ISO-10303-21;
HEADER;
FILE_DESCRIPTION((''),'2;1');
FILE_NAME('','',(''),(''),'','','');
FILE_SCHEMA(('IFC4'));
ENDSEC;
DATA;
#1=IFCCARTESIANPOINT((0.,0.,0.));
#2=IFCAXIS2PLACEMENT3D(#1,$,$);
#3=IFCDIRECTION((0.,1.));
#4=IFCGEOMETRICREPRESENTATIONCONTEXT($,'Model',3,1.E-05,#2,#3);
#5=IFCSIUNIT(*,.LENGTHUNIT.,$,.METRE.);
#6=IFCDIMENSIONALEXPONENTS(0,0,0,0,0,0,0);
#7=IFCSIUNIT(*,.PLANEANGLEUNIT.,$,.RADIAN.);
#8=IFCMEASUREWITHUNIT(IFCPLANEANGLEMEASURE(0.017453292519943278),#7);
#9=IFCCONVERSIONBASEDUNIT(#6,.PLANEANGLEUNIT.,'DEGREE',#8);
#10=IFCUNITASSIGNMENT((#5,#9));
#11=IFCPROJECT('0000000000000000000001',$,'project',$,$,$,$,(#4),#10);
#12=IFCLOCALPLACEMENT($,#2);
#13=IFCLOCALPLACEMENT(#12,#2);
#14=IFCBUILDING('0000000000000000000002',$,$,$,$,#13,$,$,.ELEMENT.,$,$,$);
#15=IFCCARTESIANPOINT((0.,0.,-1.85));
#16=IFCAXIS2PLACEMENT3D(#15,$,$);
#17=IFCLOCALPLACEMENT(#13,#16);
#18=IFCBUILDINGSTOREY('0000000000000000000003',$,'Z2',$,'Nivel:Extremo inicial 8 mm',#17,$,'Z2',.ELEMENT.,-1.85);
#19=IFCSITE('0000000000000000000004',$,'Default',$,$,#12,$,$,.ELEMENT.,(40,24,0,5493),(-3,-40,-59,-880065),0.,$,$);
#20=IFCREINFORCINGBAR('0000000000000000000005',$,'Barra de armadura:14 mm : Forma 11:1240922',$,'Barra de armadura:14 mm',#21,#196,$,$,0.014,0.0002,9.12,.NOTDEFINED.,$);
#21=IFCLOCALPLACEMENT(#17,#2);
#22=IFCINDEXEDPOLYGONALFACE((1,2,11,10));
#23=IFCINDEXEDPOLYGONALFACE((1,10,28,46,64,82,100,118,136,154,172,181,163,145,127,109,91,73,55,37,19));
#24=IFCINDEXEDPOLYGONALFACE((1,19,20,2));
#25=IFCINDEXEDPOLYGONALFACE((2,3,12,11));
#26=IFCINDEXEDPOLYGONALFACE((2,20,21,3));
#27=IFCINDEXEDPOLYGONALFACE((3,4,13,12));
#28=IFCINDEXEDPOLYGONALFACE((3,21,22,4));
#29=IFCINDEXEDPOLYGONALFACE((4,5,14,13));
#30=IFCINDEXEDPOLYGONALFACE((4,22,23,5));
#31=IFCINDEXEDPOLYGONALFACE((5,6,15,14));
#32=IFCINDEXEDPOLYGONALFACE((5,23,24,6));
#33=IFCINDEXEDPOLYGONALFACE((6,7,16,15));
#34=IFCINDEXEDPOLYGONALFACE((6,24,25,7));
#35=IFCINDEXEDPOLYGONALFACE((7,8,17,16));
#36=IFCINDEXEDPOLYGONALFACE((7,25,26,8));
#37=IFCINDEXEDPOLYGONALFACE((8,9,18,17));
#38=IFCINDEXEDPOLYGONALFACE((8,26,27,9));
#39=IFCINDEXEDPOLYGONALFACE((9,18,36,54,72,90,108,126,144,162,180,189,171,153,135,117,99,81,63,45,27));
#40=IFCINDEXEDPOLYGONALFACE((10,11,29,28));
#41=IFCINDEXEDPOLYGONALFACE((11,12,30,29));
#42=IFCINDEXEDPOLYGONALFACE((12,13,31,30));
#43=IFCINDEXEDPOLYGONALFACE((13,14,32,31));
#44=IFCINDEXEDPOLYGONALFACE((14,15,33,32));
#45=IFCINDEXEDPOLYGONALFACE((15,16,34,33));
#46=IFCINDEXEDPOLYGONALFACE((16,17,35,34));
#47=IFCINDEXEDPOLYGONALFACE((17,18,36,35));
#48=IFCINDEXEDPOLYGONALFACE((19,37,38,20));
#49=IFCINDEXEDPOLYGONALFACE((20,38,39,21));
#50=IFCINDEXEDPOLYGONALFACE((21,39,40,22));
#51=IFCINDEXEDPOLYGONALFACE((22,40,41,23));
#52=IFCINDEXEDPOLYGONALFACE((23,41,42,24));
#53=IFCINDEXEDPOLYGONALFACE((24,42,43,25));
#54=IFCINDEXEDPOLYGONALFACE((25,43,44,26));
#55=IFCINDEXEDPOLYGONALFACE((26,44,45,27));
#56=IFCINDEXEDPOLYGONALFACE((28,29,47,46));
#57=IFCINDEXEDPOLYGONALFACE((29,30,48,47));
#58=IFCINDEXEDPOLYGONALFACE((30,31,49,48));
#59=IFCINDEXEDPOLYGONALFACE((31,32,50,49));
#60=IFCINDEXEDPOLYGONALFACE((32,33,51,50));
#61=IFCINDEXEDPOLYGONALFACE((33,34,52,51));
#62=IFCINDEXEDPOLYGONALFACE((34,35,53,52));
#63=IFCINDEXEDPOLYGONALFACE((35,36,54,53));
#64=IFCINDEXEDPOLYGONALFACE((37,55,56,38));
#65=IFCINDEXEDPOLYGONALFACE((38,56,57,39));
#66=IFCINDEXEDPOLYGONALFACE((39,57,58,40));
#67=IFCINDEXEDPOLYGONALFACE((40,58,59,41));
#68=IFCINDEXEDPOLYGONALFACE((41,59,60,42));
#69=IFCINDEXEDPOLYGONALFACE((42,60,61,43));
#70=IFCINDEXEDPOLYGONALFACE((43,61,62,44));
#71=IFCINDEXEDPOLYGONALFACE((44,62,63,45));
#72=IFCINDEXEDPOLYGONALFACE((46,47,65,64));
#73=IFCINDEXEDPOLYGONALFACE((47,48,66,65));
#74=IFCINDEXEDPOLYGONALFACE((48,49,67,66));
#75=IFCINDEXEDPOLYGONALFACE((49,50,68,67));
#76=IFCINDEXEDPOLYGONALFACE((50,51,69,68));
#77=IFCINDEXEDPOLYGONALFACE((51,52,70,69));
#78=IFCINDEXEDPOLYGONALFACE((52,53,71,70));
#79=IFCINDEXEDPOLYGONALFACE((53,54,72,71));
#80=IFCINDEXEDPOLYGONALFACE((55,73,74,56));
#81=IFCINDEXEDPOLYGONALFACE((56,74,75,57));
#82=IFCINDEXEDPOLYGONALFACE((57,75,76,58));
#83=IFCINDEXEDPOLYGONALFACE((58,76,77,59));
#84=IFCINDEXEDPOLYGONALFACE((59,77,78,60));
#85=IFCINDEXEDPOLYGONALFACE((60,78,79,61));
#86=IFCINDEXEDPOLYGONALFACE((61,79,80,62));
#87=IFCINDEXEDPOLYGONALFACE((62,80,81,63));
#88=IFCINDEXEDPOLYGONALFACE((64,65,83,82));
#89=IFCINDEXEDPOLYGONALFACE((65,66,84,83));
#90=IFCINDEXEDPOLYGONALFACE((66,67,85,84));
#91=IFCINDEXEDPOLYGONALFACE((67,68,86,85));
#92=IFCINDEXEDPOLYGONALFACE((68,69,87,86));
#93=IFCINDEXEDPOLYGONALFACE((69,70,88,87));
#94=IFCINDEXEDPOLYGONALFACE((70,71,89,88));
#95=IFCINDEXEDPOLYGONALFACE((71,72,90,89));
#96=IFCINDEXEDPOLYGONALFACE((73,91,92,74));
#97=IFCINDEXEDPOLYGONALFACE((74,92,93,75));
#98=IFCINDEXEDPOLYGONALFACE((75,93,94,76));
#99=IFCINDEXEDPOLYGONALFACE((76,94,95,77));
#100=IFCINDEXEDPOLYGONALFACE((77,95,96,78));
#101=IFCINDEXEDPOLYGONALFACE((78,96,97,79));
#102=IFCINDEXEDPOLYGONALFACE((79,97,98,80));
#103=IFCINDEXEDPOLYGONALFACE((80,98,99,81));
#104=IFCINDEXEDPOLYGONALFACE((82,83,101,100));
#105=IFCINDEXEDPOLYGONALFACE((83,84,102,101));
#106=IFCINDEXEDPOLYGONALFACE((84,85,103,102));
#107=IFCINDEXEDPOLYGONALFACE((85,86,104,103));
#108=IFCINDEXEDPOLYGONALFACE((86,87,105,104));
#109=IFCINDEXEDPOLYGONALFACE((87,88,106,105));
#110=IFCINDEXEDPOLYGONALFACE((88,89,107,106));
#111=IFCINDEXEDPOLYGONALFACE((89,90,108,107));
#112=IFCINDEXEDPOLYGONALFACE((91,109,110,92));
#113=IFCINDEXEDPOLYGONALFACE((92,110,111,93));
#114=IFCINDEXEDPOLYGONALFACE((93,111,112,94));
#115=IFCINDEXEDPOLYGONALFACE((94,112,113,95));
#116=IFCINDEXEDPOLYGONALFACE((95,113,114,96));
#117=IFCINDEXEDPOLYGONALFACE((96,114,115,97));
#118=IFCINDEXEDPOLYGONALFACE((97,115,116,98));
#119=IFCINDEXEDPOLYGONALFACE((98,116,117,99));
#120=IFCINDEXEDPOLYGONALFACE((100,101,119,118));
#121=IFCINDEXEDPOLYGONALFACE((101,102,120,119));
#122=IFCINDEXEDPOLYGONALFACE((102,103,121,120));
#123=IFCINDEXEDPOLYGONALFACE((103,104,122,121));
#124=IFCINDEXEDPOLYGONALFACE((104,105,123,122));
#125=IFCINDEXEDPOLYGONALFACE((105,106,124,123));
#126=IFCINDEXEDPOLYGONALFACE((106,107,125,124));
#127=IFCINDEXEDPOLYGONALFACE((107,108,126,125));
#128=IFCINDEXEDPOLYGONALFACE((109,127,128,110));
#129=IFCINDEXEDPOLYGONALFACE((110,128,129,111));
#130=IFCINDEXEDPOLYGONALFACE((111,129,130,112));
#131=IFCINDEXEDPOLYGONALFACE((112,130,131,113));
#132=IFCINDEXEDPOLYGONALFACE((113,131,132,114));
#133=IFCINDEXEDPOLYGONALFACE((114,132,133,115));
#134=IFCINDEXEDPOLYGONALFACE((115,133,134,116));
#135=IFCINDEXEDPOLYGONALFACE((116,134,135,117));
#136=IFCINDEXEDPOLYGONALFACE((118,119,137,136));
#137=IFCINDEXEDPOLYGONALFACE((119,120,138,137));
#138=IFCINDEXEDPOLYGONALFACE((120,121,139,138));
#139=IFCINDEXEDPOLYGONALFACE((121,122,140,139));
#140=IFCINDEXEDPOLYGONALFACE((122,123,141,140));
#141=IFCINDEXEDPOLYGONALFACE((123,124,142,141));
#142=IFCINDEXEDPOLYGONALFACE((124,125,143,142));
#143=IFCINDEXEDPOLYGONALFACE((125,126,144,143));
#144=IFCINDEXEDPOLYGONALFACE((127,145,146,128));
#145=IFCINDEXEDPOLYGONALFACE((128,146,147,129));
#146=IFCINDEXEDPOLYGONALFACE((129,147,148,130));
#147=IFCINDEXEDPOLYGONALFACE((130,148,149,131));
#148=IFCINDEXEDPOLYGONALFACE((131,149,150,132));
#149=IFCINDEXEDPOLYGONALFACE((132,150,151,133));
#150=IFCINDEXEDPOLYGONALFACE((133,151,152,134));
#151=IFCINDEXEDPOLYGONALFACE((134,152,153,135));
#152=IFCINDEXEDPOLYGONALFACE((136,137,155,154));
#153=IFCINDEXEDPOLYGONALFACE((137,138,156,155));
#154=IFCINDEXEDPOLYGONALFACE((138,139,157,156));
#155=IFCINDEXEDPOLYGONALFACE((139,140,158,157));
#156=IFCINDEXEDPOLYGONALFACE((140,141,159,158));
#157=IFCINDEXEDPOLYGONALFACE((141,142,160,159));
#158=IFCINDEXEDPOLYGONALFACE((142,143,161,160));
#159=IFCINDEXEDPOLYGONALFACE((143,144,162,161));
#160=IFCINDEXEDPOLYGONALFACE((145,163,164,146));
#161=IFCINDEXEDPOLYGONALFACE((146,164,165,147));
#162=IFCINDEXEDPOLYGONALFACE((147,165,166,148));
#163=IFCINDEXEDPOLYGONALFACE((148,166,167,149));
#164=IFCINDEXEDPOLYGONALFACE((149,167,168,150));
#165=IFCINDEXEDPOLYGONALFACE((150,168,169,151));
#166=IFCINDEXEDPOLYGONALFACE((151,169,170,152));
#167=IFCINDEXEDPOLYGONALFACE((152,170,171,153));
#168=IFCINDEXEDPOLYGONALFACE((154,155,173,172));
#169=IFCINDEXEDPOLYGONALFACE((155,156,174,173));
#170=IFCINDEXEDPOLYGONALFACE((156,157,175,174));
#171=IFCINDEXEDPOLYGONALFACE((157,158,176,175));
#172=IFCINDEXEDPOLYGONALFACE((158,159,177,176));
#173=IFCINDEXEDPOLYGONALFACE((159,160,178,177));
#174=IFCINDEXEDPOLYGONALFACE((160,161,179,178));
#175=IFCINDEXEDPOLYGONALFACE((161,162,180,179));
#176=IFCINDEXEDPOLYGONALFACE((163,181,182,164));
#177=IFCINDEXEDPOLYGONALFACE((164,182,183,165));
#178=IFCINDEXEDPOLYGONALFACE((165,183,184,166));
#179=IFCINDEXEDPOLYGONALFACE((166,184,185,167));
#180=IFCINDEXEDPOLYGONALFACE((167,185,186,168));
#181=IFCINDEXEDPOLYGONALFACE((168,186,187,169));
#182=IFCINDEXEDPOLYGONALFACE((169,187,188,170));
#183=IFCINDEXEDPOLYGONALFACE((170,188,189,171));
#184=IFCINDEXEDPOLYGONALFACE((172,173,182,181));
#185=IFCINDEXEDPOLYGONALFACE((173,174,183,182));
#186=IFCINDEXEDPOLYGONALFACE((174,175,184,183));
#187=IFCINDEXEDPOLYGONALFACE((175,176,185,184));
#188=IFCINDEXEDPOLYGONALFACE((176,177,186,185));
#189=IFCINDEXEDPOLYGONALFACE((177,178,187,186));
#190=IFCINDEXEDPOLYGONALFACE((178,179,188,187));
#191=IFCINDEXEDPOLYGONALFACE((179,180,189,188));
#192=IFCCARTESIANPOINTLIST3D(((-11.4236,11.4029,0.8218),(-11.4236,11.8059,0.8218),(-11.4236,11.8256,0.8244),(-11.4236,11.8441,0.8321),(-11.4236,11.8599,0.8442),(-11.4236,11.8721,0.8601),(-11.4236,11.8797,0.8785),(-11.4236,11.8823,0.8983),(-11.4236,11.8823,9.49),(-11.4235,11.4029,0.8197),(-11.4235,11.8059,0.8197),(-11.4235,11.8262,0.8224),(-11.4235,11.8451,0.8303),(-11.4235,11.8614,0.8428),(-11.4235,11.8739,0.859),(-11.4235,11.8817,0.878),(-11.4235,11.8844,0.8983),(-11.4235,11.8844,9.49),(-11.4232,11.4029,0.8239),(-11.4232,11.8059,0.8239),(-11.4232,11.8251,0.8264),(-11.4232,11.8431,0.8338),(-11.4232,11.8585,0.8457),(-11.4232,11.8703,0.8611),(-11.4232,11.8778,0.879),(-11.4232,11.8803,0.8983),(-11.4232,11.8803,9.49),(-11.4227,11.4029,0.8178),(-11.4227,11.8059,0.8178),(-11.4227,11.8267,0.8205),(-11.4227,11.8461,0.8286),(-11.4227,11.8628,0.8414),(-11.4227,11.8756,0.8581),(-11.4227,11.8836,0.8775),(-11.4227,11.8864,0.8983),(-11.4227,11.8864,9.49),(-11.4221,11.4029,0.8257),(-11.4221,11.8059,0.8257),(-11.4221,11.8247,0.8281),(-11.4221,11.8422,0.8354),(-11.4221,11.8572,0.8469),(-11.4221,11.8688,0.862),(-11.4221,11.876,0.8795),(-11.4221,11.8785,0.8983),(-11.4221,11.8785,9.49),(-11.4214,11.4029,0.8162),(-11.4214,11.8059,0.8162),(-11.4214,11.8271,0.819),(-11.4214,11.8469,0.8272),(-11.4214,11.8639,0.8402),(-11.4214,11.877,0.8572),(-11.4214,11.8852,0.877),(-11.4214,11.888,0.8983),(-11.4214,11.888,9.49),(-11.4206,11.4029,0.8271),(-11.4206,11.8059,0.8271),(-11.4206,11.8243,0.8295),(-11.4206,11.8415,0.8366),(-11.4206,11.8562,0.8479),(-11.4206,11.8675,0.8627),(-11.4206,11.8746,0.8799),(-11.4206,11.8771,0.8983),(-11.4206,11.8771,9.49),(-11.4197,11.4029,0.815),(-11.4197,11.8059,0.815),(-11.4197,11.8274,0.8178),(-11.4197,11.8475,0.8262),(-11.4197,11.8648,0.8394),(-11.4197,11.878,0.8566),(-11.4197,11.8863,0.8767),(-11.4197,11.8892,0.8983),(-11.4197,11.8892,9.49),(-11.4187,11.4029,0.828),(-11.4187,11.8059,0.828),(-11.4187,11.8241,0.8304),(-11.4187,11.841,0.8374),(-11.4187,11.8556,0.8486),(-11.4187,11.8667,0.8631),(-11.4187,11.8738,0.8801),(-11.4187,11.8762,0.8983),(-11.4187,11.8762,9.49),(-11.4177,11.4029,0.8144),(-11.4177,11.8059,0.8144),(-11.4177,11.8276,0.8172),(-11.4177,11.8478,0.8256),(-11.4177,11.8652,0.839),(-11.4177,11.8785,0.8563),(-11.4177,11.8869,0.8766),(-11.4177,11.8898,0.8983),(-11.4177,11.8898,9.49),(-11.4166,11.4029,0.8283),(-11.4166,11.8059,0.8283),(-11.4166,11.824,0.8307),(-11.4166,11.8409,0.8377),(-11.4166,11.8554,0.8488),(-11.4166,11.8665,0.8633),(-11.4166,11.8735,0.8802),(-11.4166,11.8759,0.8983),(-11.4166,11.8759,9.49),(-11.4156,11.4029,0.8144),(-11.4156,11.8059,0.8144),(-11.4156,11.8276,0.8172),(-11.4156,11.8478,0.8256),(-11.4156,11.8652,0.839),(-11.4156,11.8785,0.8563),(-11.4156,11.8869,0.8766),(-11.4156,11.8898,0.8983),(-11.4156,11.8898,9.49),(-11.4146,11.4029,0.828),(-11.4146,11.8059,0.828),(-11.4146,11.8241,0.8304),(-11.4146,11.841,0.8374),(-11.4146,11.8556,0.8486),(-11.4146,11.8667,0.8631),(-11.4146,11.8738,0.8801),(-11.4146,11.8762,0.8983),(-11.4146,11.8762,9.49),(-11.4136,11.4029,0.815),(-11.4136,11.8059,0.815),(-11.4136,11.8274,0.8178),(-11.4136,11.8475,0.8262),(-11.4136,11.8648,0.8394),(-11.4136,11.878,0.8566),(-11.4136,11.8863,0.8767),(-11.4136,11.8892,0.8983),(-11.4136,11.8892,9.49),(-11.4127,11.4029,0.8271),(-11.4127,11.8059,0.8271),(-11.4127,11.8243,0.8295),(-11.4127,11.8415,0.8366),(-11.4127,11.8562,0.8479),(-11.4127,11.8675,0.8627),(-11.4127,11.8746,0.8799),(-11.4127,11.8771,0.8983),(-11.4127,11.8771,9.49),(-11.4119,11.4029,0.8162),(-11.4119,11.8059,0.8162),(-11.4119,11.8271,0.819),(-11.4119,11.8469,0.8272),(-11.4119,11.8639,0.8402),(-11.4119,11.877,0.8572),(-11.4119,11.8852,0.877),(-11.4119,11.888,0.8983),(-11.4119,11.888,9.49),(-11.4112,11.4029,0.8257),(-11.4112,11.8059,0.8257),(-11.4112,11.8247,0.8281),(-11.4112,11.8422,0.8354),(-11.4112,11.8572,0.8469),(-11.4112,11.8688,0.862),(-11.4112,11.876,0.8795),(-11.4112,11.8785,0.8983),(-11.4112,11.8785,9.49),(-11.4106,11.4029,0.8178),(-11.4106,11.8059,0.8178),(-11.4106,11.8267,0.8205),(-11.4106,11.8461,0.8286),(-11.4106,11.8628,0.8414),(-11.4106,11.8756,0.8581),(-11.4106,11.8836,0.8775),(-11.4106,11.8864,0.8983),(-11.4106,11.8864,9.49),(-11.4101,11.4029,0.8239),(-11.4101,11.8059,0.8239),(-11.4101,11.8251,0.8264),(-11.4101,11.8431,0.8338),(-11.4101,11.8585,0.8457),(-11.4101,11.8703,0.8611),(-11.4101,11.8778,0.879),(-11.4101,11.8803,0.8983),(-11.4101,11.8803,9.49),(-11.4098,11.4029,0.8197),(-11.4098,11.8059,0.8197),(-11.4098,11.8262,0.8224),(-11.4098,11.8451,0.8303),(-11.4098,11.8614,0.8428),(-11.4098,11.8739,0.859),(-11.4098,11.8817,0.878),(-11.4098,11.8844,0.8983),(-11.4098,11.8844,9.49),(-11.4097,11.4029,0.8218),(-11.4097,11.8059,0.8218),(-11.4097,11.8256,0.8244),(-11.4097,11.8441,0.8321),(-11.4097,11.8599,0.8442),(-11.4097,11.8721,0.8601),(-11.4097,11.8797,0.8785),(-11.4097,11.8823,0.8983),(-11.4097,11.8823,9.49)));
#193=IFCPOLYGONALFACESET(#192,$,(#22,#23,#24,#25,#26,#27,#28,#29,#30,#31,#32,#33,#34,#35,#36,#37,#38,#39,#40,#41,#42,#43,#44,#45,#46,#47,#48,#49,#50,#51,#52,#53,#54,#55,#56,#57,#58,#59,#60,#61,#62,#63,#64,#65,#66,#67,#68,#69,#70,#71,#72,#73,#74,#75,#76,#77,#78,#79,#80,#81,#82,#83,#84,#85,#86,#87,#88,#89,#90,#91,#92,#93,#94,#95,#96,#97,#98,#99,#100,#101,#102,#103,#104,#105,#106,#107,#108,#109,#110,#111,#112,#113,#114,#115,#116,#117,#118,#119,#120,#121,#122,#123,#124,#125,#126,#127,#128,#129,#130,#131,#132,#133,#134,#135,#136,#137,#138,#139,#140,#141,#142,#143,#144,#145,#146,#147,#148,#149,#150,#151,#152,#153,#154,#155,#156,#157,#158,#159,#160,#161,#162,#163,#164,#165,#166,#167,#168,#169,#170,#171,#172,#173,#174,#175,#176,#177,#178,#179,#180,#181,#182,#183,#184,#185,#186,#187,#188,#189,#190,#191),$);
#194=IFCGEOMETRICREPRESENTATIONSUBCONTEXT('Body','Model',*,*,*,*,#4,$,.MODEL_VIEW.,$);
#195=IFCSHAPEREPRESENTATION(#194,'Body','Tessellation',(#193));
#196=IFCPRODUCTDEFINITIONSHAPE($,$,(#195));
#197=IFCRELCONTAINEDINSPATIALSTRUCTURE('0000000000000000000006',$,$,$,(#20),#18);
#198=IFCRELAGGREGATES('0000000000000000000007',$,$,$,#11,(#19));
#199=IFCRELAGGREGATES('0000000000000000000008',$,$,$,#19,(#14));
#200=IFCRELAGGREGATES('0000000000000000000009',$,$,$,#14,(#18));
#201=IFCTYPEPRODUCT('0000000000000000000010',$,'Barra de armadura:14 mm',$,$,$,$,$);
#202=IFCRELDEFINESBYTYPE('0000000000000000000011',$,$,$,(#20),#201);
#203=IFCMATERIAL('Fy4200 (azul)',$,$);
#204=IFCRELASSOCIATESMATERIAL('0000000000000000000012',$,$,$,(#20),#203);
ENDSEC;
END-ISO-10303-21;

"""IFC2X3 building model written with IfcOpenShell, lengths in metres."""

from ifc_helpers import new_model, entity, si_unit, converted_unit, direction, frame, origin, place, context, subcontext, project, spatial, material, type_object, element, save


model = new_model("IFC2X3")

# Units and contexts
model_context = context("Model", 3, precision=1e-05, world=origin(), true_north=direction((0.0, 1.0)))
body_context = subcontext(model_context, "Body", "Model", "MODEL_VIEW")
ifc_project = project(units=[si_unit("LENGTHUNIT", "METRE"), converted_unit("PLANEANGLEUNIT", "DEGREE", entity("IfcPlaneAngleMeasure", 0.017453292519943278), si_unit("PLANEANGLEUNIT", "RADIAN"), dimensions=[0, 0, 0, 0, 0, 0, 0])], contexts=[model_context])

# Site, building, storey
site_placement = place(None, origin())
site = spatial("IfcSite", under=ifc_project, at=site_placement, Name="Default", CompositionType="ELEMENT", RefLatitude=(40, 24, 0, 5493), RefLongitude=(-3, -40, -59, -880065), RefElevation=0.0)
building_placement = place(site_placement, origin())
building = spatial("IfcBuilding", under=site, at=building_placement, CompositionType="ELEMENT")
storey_placement = place(building_placement, frame((0.0, 0.0, -1.85)))
storey = spatial("IfcBuildingStorey", under=building, at=storey_placement, Name="Z2", ObjectType="Nivel:Extremo inicial 8 mm", LongName="Z2", CompositionType="ELEMENT", Elevation=-1.85)

# Reinforcing bar
ifc_material_1 = material(Name="Fy4200 (azul)")
type_product_1 = type_object("IfcTypeProduct", Name="Barra de armadura:14 mm")
reinforcing_bar_1_placement = place(storey_placement, origin())
element("IfcReinforcingBar", 1, at=reinforcing_bar_1_placement, inside=storey, type_object=type_product_1, material=ifc_material_1, Name="Barra de armadura:14 mm : Forma 11:1240922", ObjectType="Barra de armadura:14 mm", BarLength=9.12, BarRole="NOTDEFINED", CrossSectionArea=0.0002, NominalDiameter=0.014, context=body_context, shape_type="AdvancedSweptSolid", body=[
    entity("IfcSweptDiskSolid", entity("IfcCompositeCurve", [entity("IfcCompositeCurveSegment", "CONTINUOUS", True, entity("IfcPolyline", [entity("IfcCartesianPoint", [-11.4166, 11.8829, 9.49]), entity("IfcCartesianPoint", [-11.4166, 11.8829, 0.8983])])), entity("IfcCompositeCurveSegment", "CONTINUOUS", True, entity("IfcTrimmedCurve", entity("IfcCircle", entity("IfcAxis2Placement3D", entity("IfcCartesianPoint", [-11.4166, 11.8059, 0.8983]), entity("IfcDirection", [-1.0, 0.0, 0.0]), entity("IfcDirection", [0.0, 0.0, -1.0])), 0.077), [entity("IfcParameterValue", 270.0)], [entity("IfcParameterValue", 360.0)], True, "PARAMETER")), entity("IfcCompositeCurveSegment", "CONTINUOUS", True, entity("IfcPolyline", [entity("IfcCartesianPoint", [-11.4166, 11.8059, 0.8213]), entity("IfcCartesianPoint", [-11.4166, 11.4029, 0.8213])]))], False), 0.007, None, 0.0, 92.0),
])

save(model, "model.ifc")
